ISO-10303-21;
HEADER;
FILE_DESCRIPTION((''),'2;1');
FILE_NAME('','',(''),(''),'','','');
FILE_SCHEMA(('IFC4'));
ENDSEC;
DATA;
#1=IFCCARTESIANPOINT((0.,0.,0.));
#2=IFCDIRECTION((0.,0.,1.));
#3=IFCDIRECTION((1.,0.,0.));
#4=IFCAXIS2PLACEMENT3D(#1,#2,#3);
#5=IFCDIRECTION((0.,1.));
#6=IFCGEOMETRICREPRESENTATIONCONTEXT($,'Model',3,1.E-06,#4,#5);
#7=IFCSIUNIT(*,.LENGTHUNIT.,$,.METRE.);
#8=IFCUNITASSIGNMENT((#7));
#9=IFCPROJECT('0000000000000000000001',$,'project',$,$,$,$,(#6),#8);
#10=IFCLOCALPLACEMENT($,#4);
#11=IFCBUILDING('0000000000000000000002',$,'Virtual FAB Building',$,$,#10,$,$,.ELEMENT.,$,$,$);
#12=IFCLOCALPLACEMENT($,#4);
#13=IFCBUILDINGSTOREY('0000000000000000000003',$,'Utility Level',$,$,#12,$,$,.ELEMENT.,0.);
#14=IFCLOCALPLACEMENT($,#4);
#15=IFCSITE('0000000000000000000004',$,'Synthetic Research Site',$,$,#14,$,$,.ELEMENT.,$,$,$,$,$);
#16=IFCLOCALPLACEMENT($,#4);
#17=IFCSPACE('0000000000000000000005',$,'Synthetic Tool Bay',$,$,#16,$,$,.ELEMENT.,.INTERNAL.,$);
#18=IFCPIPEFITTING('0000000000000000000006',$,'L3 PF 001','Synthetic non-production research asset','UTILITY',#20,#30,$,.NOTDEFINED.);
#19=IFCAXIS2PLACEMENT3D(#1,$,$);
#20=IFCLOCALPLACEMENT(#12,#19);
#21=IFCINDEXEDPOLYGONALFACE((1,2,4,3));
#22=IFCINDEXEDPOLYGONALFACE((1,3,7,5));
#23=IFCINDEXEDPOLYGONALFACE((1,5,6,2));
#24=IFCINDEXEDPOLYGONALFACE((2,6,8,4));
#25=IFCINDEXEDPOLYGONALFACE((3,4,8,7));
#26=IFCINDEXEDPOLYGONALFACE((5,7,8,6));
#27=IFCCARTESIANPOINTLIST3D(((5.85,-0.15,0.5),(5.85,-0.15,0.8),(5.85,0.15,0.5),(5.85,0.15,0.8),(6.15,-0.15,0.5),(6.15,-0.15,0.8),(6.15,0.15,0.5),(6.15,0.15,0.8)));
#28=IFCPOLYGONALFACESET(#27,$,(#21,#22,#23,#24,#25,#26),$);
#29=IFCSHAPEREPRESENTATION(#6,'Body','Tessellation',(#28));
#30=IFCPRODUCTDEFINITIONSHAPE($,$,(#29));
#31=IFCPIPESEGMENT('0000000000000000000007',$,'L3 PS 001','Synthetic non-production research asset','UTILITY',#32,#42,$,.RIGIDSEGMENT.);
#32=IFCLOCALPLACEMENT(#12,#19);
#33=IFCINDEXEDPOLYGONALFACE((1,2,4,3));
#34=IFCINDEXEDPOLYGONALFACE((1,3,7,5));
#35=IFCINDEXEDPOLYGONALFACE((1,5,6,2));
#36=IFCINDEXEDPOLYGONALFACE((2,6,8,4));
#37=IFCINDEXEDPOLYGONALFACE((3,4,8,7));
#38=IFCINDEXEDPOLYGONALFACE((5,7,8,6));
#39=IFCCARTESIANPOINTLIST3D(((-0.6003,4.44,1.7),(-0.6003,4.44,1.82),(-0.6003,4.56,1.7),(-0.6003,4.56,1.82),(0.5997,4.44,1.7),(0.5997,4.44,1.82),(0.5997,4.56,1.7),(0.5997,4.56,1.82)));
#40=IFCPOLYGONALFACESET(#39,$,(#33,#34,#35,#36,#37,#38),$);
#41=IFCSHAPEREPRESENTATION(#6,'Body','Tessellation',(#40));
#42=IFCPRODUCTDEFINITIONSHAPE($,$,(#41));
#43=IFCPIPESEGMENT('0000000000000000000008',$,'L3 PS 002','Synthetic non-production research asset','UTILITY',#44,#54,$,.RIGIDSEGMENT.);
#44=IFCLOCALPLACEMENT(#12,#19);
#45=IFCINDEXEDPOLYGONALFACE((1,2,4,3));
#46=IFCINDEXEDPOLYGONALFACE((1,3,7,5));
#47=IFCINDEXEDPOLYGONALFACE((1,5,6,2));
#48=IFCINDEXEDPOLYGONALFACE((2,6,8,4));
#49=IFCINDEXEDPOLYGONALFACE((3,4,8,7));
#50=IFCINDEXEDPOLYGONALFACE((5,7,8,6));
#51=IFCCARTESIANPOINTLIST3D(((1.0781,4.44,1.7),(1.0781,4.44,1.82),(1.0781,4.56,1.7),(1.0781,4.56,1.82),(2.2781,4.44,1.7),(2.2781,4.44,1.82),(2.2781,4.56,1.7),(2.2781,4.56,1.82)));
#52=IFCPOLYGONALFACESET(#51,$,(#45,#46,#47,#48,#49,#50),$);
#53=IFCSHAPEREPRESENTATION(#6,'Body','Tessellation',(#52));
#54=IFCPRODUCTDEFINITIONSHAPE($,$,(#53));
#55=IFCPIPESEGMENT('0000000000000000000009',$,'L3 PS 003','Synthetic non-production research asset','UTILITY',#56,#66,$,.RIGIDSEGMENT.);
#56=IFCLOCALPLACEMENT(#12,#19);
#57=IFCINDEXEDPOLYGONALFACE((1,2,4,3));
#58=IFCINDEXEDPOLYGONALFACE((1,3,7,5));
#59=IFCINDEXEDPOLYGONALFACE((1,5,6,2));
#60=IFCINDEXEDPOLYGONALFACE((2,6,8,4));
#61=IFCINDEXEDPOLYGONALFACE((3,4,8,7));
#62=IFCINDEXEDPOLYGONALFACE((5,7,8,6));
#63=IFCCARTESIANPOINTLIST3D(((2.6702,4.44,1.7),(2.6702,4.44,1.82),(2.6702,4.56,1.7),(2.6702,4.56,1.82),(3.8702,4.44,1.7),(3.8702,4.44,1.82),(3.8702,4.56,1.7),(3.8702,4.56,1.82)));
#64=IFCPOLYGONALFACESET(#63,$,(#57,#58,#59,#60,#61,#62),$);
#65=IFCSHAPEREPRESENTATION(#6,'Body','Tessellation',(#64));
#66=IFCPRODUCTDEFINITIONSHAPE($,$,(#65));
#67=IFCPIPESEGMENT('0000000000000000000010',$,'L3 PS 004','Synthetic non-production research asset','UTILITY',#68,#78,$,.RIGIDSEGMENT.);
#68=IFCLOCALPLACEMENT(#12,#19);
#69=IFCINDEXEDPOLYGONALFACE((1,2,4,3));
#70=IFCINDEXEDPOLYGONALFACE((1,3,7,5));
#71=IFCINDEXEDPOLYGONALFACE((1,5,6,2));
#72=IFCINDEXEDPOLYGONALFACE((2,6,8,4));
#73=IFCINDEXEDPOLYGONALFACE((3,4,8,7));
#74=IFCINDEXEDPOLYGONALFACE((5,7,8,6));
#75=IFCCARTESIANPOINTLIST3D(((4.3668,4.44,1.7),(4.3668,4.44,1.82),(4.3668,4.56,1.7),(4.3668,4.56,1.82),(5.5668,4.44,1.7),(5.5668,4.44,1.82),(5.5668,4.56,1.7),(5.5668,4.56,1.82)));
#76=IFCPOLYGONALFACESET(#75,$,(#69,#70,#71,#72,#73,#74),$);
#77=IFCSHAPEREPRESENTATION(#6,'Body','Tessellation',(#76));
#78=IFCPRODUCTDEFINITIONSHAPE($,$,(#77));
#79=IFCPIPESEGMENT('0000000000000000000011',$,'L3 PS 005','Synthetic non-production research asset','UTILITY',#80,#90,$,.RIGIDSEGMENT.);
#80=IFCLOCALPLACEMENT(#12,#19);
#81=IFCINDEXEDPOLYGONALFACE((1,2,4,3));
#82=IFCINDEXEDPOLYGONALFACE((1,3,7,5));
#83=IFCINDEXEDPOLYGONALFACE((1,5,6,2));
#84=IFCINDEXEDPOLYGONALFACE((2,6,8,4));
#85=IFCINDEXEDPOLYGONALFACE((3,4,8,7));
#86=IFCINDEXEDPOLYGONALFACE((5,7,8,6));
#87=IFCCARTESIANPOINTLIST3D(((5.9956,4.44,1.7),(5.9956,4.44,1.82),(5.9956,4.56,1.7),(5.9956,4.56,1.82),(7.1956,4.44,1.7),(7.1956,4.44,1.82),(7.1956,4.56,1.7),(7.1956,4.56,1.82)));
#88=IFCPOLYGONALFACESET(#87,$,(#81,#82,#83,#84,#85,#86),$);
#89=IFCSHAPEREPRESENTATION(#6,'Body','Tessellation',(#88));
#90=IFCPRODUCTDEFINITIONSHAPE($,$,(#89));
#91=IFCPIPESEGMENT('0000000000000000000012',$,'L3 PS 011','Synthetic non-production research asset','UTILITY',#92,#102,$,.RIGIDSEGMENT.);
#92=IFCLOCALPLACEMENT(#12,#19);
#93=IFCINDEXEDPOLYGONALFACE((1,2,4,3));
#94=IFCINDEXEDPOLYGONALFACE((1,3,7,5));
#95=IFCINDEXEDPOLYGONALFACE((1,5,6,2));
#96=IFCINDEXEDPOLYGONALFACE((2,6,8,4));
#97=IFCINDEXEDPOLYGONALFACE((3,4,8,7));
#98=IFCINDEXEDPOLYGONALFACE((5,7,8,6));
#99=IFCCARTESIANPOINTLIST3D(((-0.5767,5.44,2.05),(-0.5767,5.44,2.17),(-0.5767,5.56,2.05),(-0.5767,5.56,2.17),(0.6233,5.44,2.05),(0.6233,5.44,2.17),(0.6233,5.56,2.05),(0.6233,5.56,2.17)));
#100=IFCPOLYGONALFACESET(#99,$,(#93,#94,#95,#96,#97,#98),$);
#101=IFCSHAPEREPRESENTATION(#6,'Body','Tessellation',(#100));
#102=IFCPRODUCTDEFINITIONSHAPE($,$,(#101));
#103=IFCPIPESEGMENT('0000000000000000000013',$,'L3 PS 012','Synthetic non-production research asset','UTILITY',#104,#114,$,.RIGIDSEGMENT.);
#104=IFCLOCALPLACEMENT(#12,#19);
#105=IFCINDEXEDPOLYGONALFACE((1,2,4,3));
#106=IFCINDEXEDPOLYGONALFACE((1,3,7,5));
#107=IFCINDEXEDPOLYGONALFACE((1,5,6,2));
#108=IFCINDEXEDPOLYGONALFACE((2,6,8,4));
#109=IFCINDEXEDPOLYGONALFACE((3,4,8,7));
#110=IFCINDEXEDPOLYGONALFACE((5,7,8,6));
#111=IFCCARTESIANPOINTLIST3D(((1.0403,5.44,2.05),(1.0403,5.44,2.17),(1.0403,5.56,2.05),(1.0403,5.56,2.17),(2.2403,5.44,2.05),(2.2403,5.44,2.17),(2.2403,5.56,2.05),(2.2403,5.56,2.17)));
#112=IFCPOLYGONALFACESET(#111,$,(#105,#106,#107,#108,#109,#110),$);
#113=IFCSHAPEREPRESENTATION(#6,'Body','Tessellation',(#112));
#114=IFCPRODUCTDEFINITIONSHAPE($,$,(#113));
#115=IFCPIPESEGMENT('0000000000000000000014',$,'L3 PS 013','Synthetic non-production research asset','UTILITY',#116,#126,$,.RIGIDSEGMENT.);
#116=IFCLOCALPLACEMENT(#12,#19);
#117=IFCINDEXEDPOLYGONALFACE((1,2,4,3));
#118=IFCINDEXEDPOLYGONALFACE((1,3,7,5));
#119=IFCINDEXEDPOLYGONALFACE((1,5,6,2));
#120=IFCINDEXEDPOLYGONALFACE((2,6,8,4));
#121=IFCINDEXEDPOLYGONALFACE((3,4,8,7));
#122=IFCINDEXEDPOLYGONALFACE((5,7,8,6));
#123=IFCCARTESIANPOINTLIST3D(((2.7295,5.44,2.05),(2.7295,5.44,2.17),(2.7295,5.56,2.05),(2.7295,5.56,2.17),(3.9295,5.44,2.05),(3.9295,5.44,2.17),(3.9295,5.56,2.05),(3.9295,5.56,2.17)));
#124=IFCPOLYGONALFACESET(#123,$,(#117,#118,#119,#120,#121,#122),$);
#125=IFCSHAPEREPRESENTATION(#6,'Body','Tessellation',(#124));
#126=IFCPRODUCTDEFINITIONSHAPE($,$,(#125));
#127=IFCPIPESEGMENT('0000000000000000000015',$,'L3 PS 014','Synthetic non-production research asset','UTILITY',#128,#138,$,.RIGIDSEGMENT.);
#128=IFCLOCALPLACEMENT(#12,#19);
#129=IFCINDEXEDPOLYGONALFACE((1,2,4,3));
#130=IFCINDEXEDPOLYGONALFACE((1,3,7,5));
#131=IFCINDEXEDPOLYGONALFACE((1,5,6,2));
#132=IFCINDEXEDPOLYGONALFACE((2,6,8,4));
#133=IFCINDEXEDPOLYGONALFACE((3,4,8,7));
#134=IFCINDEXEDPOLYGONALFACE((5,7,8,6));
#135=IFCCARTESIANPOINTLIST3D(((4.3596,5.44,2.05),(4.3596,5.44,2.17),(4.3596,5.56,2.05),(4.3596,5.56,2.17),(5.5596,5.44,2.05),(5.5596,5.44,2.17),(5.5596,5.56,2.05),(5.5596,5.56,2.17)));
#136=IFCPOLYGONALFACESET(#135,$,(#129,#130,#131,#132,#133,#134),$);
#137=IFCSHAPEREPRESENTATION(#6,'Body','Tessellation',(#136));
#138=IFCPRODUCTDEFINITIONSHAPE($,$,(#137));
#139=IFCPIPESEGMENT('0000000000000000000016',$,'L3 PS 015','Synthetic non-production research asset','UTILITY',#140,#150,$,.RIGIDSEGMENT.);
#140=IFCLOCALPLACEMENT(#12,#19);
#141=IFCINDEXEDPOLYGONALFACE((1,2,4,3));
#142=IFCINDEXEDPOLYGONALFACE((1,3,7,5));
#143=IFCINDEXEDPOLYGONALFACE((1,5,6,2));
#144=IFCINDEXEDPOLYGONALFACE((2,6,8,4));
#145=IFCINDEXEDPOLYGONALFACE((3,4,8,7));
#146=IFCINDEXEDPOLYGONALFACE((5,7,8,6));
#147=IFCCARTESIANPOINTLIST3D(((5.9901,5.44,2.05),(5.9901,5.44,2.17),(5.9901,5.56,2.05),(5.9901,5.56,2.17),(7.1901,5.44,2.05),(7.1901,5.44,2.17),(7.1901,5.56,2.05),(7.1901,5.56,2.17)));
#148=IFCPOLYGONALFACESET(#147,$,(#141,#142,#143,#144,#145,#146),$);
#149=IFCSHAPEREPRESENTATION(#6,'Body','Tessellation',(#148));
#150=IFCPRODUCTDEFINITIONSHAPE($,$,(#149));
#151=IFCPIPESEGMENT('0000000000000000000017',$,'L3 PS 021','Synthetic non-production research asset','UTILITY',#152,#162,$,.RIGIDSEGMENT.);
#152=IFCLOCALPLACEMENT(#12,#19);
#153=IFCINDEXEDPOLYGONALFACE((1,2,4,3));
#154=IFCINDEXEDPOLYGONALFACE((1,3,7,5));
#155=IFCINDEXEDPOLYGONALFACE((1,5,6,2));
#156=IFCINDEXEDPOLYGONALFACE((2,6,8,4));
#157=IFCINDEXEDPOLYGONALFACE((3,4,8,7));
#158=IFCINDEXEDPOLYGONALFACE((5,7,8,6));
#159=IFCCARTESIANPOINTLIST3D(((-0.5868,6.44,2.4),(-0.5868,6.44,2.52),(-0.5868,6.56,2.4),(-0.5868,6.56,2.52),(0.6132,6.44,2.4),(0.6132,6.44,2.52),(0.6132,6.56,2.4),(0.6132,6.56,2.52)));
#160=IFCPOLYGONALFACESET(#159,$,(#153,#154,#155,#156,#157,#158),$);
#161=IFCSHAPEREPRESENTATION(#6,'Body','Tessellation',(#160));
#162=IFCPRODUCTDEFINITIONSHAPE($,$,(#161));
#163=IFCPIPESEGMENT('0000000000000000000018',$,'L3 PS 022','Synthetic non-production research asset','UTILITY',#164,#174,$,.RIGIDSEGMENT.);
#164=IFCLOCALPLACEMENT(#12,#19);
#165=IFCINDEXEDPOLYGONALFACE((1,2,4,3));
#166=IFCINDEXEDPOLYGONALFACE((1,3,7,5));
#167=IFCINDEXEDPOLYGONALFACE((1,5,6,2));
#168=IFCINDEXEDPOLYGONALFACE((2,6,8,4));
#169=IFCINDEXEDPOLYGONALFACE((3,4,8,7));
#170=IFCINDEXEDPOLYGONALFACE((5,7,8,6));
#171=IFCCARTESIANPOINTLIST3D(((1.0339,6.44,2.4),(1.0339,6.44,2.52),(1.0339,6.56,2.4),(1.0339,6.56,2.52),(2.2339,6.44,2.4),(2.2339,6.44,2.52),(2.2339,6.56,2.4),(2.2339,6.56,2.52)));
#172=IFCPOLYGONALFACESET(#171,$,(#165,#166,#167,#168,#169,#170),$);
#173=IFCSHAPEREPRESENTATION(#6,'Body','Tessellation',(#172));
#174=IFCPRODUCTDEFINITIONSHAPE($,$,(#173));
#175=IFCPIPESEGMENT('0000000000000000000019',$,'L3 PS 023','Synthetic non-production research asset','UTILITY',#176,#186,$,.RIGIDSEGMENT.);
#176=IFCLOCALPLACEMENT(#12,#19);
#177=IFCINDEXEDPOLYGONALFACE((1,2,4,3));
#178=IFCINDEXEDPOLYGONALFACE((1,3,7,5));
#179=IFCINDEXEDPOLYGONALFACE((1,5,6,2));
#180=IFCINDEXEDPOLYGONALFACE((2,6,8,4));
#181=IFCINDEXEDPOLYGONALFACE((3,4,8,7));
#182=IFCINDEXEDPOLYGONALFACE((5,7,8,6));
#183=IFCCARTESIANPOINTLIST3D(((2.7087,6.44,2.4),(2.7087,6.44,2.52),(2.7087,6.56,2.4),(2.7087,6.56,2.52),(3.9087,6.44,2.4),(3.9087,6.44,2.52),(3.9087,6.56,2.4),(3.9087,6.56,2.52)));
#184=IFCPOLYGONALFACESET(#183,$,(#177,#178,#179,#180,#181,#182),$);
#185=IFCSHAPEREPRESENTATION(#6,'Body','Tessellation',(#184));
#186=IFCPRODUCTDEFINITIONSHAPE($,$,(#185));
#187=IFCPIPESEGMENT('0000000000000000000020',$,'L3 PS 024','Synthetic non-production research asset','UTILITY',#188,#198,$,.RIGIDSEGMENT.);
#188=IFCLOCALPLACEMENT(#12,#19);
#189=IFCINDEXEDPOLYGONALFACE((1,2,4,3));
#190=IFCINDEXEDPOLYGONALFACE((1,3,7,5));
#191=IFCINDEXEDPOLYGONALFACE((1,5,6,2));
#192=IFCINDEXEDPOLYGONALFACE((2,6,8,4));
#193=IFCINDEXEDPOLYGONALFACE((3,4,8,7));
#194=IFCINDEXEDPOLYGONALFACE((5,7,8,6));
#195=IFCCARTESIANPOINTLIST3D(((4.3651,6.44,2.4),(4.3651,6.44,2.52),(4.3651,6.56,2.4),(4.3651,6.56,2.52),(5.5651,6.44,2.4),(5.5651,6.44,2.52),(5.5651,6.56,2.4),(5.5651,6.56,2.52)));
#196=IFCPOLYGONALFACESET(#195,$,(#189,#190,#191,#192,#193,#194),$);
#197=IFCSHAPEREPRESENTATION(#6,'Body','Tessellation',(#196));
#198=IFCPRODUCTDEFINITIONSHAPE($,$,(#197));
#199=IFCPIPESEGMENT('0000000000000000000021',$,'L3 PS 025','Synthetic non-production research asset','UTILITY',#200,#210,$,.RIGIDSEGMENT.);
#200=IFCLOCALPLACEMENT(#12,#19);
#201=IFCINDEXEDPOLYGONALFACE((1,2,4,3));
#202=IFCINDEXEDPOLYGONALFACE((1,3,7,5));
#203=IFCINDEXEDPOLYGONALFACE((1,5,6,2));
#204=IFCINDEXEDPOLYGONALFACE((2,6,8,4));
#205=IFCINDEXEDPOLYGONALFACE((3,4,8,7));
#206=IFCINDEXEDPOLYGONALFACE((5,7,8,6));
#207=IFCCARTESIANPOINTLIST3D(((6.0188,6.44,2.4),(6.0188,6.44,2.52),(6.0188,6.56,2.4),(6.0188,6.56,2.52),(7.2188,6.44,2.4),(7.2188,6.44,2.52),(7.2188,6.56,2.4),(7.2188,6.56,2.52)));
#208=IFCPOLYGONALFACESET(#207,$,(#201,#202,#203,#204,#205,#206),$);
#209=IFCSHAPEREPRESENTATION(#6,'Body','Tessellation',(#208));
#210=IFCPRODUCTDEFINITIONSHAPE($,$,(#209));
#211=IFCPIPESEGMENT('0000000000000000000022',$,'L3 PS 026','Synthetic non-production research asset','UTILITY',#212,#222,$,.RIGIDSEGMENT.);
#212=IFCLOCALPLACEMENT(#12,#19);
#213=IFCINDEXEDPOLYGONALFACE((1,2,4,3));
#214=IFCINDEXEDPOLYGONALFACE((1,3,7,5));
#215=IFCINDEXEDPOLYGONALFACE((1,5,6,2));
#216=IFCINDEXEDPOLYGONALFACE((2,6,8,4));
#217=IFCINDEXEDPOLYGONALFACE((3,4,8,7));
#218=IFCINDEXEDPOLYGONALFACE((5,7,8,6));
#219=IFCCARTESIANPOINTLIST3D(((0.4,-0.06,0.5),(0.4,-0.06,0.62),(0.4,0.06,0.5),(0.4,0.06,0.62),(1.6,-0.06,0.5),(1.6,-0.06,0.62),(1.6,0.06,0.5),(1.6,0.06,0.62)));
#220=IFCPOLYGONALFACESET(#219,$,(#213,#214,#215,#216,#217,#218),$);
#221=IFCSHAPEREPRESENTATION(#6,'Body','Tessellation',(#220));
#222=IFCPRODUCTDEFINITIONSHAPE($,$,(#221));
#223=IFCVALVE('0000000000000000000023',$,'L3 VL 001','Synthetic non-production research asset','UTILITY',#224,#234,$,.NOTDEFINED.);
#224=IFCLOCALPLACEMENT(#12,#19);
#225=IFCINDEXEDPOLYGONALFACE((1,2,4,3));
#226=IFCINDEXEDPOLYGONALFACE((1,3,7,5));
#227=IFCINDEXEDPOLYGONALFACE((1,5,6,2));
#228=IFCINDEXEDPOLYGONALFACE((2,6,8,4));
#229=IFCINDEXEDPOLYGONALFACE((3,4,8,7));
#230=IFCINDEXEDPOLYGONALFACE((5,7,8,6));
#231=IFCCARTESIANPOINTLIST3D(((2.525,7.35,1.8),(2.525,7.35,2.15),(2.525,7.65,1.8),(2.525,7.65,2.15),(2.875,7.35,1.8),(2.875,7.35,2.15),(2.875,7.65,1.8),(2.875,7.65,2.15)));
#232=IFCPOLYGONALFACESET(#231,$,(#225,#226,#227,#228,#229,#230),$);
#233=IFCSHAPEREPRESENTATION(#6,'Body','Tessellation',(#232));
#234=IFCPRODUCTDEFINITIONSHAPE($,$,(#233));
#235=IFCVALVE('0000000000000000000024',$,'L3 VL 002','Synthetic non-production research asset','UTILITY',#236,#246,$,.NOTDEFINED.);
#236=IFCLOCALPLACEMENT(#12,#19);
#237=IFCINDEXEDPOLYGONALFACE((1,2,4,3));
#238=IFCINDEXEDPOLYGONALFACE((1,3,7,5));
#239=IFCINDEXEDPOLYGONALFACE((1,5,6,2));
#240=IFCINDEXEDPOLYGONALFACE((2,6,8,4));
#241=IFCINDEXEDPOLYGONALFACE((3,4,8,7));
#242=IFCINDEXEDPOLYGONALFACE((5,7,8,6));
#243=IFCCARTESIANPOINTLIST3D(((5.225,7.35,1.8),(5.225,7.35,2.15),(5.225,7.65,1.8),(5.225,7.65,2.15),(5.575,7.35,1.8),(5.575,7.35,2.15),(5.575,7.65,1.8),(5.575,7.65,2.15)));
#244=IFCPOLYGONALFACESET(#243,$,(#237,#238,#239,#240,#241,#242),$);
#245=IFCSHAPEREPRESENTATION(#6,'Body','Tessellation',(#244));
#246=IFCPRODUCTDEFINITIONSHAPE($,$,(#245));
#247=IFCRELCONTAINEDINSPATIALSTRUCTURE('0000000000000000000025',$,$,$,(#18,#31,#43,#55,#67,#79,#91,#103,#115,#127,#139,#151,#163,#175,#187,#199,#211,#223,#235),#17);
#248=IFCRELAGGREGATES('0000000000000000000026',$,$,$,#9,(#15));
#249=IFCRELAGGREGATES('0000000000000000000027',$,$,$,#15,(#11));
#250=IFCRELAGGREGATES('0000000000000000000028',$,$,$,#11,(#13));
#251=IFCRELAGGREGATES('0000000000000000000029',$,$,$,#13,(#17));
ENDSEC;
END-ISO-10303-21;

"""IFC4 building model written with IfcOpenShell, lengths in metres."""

from ifc_helpers import new_model, si_unit, direction, frame, origin_with_axes, origin_2d_with_axis, place, context, project, spatial, rectangle, extrude, element, save


model = new_model("IFC4")

# Units and contexts
model_context = context("Model", 3, precision=1e-06, world=origin_with_axes(), true_north=direction((0.0, 1.0)))
ifc_project = project(units=[si_unit("LENGTHUNIT", "METRE")], contexts=[model_context])

# Site, building, storey, space
site_placement = place(None, origin_with_axes())
site = spatial("IfcSite", under=ifc_project, at=site_placement, Name="Synthetic Research Site", CompositionType="ELEMENT")
building_placement = place(None, origin_with_axes())
building = spatial("IfcBuilding", under=site, at=building_placement, Name="Virtual FAB Building", CompositionType="ELEMENT")
storey_placement = place(None, origin_with_axes())
storey = spatial("IfcBuildingStorey", under=building, at=storey_placement, Name="Utility Level", CompositionType="ELEMENT", Elevation=0.0)
space_placement = place(None, origin_with_axes())
space = spatial("IfcSpace", under=storey, at=space_placement, Name="Synthetic Tool Bay", CompositionType="ELEMENT", PredefinedType="INTERNAL")

# Pipe fitting
pipe_fitting_placement = place(None, frame((6.0, 0.0, 0.5), z_axis=(0.0, 0.0, 1.0), x_axis=(1.0, 0.0, 0.0)))
element("IfcPipeFitting", 1, at=pipe_fitting_placement, inside=space, Name="L3 PF 001", Description="Synthetic non-production research asset", ObjectType="UTILITY", PredefinedType="NOTDEFINED", context=model_context, shape_type="SweptSolid", body=[
    extrude(rectangle(XDim=0.3, YDim=0.3, at=origin_2d_with_axis()), origin_with_axes(), (0.0, 0.0, 1.0), 0.3),
])

# Pipe segments
for number, where, z_axis, x_axis, name in (
    (2, (-0.0003, 4.5, 1.7), (0.0, 0.0, 1.0), (1.0, 0.0, 0.0), "L3 PS 001"),
    (3, (1.6781, 4.5, 1.7), (0.0, 0.0, 1.0), (1.0, 0.0, 0.0), "L3 PS 002"),
    (4, (3.2702, 4.5, 1.7), (0.0, 0.0, 1.0), (1.0, 0.0, 0.0), "L3 PS 003"),
    (5, (4.9668, 4.5, 1.7), (0.0, 0.0, 1.0), (1.0, 0.0, 0.0), "L3 PS 004"),
    (6, (6.5956, 4.5, 1.7), (0.0, 0.0, 1.0), (1.0, 0.0, 0.0), "L3 PS 005"),
    (7, (0.0233, 5.5, 2.05), (0.0, 0.0, 1.0), (1.0, 0.0, 0.0), "L3 PS 011"),
    (8, (1.6403, 5.5, 2.05), (0.0, 0.0, 1.0), (1.0, 0.0, 0.0), "L3 PS 012"),
    (9, (3.3295, 5.5, 2.05), (0.0, 0.0, 1.0), (1.0, 0.0, 0.0), "L3 PS 013"),
    (10, (4.9596, 5.5, 2.05), (0.0, 0.0, 1.0), (1.0, 0.0, 0.0), "L3 PS 014"),
    (11, (6.5901, 5.5, 2.05), (0.0, 0.0, 1.0), (1.0, 0.0, 0.0), "L3 PS 015"),
    (12, (0.0132, 6.5, 2.4), (0.0, 0.0, 1.0), (1.0, 0.0, 0.0), "L3 PS 021"),
    (13, (1.6339, 6.5, 2.4), (0.0, 0.0, 1.0), (1.0, 0.0, 0.0), "L3 PS 022"),
    (14, (3.3087, 6.5, 2.4), (0.0, 0.0, 1.0), (1.0, 0.0, 0.0), "L3 PS 023"),
    (15, (4.9651, 6.5, 2.4), (0.0, 0.0, 1.0), (1.0, 0.0, 0.0), "L3 PS 024"),
    (16, (6.6188, 6.5, 2.4), (0.0, 0.0, 1.0), (1.0, 0.0, 0.0), "L3 PS 025"),
    (17, (1.0, 0.0, 0.5), (0.0, 0.0, 1.0), (1.0, 0.0, 0.0), "L3 PS 026"),
):
    element("IfcPipeSegment", number, at=place(None, frame(where, z_axis=z_axis, x_axis=x_axis)), inside=space, Name=name, Description="Synthetic non-production research asset", ObjectType="UTILITY", PredefinedType="RIGIDSEGMENT", context=model_context, shape_type="SweptSolid", body=[
        extrude(rectangle(XDim=1.2, YDim=0.12, at=origin_2d_with_axis()), origin_with_axes(), (0.0, 0.0, 1.0), 0.12),
    ])

# Valves
for number, where, z_axis, x_axis, name in (
    (18, (2.7, 7.5, 1.8), (0.0, 0.0, 1.0), (1.0, 0.0, 0.0), "L3 VL 001"),
    (19, (5.4, 7.5, 1.8), (0.0, 0.0, 1.0), (1.0, 0.0, 0.0), "L3 VL 002"),
):
    element("IfcValve", number, at=place(None, frame(where, z_axis=z_axis, x_axis=x_axis)), inside=space, Name=name, Description="Synthetic non-production research asset", ObjectType="UTILITY", PredefinedType="NOTDEFINED", context=model_context, shape_type="SweptSolid", body=[
        extrude(rectangle(XDim=0.35, YDim=0.3, at=origin_2d_with_axis()), origin_with_axes(), (0.0, 0.0, 1.0), 0.35),
    ])

save(model, "model.ifc")
